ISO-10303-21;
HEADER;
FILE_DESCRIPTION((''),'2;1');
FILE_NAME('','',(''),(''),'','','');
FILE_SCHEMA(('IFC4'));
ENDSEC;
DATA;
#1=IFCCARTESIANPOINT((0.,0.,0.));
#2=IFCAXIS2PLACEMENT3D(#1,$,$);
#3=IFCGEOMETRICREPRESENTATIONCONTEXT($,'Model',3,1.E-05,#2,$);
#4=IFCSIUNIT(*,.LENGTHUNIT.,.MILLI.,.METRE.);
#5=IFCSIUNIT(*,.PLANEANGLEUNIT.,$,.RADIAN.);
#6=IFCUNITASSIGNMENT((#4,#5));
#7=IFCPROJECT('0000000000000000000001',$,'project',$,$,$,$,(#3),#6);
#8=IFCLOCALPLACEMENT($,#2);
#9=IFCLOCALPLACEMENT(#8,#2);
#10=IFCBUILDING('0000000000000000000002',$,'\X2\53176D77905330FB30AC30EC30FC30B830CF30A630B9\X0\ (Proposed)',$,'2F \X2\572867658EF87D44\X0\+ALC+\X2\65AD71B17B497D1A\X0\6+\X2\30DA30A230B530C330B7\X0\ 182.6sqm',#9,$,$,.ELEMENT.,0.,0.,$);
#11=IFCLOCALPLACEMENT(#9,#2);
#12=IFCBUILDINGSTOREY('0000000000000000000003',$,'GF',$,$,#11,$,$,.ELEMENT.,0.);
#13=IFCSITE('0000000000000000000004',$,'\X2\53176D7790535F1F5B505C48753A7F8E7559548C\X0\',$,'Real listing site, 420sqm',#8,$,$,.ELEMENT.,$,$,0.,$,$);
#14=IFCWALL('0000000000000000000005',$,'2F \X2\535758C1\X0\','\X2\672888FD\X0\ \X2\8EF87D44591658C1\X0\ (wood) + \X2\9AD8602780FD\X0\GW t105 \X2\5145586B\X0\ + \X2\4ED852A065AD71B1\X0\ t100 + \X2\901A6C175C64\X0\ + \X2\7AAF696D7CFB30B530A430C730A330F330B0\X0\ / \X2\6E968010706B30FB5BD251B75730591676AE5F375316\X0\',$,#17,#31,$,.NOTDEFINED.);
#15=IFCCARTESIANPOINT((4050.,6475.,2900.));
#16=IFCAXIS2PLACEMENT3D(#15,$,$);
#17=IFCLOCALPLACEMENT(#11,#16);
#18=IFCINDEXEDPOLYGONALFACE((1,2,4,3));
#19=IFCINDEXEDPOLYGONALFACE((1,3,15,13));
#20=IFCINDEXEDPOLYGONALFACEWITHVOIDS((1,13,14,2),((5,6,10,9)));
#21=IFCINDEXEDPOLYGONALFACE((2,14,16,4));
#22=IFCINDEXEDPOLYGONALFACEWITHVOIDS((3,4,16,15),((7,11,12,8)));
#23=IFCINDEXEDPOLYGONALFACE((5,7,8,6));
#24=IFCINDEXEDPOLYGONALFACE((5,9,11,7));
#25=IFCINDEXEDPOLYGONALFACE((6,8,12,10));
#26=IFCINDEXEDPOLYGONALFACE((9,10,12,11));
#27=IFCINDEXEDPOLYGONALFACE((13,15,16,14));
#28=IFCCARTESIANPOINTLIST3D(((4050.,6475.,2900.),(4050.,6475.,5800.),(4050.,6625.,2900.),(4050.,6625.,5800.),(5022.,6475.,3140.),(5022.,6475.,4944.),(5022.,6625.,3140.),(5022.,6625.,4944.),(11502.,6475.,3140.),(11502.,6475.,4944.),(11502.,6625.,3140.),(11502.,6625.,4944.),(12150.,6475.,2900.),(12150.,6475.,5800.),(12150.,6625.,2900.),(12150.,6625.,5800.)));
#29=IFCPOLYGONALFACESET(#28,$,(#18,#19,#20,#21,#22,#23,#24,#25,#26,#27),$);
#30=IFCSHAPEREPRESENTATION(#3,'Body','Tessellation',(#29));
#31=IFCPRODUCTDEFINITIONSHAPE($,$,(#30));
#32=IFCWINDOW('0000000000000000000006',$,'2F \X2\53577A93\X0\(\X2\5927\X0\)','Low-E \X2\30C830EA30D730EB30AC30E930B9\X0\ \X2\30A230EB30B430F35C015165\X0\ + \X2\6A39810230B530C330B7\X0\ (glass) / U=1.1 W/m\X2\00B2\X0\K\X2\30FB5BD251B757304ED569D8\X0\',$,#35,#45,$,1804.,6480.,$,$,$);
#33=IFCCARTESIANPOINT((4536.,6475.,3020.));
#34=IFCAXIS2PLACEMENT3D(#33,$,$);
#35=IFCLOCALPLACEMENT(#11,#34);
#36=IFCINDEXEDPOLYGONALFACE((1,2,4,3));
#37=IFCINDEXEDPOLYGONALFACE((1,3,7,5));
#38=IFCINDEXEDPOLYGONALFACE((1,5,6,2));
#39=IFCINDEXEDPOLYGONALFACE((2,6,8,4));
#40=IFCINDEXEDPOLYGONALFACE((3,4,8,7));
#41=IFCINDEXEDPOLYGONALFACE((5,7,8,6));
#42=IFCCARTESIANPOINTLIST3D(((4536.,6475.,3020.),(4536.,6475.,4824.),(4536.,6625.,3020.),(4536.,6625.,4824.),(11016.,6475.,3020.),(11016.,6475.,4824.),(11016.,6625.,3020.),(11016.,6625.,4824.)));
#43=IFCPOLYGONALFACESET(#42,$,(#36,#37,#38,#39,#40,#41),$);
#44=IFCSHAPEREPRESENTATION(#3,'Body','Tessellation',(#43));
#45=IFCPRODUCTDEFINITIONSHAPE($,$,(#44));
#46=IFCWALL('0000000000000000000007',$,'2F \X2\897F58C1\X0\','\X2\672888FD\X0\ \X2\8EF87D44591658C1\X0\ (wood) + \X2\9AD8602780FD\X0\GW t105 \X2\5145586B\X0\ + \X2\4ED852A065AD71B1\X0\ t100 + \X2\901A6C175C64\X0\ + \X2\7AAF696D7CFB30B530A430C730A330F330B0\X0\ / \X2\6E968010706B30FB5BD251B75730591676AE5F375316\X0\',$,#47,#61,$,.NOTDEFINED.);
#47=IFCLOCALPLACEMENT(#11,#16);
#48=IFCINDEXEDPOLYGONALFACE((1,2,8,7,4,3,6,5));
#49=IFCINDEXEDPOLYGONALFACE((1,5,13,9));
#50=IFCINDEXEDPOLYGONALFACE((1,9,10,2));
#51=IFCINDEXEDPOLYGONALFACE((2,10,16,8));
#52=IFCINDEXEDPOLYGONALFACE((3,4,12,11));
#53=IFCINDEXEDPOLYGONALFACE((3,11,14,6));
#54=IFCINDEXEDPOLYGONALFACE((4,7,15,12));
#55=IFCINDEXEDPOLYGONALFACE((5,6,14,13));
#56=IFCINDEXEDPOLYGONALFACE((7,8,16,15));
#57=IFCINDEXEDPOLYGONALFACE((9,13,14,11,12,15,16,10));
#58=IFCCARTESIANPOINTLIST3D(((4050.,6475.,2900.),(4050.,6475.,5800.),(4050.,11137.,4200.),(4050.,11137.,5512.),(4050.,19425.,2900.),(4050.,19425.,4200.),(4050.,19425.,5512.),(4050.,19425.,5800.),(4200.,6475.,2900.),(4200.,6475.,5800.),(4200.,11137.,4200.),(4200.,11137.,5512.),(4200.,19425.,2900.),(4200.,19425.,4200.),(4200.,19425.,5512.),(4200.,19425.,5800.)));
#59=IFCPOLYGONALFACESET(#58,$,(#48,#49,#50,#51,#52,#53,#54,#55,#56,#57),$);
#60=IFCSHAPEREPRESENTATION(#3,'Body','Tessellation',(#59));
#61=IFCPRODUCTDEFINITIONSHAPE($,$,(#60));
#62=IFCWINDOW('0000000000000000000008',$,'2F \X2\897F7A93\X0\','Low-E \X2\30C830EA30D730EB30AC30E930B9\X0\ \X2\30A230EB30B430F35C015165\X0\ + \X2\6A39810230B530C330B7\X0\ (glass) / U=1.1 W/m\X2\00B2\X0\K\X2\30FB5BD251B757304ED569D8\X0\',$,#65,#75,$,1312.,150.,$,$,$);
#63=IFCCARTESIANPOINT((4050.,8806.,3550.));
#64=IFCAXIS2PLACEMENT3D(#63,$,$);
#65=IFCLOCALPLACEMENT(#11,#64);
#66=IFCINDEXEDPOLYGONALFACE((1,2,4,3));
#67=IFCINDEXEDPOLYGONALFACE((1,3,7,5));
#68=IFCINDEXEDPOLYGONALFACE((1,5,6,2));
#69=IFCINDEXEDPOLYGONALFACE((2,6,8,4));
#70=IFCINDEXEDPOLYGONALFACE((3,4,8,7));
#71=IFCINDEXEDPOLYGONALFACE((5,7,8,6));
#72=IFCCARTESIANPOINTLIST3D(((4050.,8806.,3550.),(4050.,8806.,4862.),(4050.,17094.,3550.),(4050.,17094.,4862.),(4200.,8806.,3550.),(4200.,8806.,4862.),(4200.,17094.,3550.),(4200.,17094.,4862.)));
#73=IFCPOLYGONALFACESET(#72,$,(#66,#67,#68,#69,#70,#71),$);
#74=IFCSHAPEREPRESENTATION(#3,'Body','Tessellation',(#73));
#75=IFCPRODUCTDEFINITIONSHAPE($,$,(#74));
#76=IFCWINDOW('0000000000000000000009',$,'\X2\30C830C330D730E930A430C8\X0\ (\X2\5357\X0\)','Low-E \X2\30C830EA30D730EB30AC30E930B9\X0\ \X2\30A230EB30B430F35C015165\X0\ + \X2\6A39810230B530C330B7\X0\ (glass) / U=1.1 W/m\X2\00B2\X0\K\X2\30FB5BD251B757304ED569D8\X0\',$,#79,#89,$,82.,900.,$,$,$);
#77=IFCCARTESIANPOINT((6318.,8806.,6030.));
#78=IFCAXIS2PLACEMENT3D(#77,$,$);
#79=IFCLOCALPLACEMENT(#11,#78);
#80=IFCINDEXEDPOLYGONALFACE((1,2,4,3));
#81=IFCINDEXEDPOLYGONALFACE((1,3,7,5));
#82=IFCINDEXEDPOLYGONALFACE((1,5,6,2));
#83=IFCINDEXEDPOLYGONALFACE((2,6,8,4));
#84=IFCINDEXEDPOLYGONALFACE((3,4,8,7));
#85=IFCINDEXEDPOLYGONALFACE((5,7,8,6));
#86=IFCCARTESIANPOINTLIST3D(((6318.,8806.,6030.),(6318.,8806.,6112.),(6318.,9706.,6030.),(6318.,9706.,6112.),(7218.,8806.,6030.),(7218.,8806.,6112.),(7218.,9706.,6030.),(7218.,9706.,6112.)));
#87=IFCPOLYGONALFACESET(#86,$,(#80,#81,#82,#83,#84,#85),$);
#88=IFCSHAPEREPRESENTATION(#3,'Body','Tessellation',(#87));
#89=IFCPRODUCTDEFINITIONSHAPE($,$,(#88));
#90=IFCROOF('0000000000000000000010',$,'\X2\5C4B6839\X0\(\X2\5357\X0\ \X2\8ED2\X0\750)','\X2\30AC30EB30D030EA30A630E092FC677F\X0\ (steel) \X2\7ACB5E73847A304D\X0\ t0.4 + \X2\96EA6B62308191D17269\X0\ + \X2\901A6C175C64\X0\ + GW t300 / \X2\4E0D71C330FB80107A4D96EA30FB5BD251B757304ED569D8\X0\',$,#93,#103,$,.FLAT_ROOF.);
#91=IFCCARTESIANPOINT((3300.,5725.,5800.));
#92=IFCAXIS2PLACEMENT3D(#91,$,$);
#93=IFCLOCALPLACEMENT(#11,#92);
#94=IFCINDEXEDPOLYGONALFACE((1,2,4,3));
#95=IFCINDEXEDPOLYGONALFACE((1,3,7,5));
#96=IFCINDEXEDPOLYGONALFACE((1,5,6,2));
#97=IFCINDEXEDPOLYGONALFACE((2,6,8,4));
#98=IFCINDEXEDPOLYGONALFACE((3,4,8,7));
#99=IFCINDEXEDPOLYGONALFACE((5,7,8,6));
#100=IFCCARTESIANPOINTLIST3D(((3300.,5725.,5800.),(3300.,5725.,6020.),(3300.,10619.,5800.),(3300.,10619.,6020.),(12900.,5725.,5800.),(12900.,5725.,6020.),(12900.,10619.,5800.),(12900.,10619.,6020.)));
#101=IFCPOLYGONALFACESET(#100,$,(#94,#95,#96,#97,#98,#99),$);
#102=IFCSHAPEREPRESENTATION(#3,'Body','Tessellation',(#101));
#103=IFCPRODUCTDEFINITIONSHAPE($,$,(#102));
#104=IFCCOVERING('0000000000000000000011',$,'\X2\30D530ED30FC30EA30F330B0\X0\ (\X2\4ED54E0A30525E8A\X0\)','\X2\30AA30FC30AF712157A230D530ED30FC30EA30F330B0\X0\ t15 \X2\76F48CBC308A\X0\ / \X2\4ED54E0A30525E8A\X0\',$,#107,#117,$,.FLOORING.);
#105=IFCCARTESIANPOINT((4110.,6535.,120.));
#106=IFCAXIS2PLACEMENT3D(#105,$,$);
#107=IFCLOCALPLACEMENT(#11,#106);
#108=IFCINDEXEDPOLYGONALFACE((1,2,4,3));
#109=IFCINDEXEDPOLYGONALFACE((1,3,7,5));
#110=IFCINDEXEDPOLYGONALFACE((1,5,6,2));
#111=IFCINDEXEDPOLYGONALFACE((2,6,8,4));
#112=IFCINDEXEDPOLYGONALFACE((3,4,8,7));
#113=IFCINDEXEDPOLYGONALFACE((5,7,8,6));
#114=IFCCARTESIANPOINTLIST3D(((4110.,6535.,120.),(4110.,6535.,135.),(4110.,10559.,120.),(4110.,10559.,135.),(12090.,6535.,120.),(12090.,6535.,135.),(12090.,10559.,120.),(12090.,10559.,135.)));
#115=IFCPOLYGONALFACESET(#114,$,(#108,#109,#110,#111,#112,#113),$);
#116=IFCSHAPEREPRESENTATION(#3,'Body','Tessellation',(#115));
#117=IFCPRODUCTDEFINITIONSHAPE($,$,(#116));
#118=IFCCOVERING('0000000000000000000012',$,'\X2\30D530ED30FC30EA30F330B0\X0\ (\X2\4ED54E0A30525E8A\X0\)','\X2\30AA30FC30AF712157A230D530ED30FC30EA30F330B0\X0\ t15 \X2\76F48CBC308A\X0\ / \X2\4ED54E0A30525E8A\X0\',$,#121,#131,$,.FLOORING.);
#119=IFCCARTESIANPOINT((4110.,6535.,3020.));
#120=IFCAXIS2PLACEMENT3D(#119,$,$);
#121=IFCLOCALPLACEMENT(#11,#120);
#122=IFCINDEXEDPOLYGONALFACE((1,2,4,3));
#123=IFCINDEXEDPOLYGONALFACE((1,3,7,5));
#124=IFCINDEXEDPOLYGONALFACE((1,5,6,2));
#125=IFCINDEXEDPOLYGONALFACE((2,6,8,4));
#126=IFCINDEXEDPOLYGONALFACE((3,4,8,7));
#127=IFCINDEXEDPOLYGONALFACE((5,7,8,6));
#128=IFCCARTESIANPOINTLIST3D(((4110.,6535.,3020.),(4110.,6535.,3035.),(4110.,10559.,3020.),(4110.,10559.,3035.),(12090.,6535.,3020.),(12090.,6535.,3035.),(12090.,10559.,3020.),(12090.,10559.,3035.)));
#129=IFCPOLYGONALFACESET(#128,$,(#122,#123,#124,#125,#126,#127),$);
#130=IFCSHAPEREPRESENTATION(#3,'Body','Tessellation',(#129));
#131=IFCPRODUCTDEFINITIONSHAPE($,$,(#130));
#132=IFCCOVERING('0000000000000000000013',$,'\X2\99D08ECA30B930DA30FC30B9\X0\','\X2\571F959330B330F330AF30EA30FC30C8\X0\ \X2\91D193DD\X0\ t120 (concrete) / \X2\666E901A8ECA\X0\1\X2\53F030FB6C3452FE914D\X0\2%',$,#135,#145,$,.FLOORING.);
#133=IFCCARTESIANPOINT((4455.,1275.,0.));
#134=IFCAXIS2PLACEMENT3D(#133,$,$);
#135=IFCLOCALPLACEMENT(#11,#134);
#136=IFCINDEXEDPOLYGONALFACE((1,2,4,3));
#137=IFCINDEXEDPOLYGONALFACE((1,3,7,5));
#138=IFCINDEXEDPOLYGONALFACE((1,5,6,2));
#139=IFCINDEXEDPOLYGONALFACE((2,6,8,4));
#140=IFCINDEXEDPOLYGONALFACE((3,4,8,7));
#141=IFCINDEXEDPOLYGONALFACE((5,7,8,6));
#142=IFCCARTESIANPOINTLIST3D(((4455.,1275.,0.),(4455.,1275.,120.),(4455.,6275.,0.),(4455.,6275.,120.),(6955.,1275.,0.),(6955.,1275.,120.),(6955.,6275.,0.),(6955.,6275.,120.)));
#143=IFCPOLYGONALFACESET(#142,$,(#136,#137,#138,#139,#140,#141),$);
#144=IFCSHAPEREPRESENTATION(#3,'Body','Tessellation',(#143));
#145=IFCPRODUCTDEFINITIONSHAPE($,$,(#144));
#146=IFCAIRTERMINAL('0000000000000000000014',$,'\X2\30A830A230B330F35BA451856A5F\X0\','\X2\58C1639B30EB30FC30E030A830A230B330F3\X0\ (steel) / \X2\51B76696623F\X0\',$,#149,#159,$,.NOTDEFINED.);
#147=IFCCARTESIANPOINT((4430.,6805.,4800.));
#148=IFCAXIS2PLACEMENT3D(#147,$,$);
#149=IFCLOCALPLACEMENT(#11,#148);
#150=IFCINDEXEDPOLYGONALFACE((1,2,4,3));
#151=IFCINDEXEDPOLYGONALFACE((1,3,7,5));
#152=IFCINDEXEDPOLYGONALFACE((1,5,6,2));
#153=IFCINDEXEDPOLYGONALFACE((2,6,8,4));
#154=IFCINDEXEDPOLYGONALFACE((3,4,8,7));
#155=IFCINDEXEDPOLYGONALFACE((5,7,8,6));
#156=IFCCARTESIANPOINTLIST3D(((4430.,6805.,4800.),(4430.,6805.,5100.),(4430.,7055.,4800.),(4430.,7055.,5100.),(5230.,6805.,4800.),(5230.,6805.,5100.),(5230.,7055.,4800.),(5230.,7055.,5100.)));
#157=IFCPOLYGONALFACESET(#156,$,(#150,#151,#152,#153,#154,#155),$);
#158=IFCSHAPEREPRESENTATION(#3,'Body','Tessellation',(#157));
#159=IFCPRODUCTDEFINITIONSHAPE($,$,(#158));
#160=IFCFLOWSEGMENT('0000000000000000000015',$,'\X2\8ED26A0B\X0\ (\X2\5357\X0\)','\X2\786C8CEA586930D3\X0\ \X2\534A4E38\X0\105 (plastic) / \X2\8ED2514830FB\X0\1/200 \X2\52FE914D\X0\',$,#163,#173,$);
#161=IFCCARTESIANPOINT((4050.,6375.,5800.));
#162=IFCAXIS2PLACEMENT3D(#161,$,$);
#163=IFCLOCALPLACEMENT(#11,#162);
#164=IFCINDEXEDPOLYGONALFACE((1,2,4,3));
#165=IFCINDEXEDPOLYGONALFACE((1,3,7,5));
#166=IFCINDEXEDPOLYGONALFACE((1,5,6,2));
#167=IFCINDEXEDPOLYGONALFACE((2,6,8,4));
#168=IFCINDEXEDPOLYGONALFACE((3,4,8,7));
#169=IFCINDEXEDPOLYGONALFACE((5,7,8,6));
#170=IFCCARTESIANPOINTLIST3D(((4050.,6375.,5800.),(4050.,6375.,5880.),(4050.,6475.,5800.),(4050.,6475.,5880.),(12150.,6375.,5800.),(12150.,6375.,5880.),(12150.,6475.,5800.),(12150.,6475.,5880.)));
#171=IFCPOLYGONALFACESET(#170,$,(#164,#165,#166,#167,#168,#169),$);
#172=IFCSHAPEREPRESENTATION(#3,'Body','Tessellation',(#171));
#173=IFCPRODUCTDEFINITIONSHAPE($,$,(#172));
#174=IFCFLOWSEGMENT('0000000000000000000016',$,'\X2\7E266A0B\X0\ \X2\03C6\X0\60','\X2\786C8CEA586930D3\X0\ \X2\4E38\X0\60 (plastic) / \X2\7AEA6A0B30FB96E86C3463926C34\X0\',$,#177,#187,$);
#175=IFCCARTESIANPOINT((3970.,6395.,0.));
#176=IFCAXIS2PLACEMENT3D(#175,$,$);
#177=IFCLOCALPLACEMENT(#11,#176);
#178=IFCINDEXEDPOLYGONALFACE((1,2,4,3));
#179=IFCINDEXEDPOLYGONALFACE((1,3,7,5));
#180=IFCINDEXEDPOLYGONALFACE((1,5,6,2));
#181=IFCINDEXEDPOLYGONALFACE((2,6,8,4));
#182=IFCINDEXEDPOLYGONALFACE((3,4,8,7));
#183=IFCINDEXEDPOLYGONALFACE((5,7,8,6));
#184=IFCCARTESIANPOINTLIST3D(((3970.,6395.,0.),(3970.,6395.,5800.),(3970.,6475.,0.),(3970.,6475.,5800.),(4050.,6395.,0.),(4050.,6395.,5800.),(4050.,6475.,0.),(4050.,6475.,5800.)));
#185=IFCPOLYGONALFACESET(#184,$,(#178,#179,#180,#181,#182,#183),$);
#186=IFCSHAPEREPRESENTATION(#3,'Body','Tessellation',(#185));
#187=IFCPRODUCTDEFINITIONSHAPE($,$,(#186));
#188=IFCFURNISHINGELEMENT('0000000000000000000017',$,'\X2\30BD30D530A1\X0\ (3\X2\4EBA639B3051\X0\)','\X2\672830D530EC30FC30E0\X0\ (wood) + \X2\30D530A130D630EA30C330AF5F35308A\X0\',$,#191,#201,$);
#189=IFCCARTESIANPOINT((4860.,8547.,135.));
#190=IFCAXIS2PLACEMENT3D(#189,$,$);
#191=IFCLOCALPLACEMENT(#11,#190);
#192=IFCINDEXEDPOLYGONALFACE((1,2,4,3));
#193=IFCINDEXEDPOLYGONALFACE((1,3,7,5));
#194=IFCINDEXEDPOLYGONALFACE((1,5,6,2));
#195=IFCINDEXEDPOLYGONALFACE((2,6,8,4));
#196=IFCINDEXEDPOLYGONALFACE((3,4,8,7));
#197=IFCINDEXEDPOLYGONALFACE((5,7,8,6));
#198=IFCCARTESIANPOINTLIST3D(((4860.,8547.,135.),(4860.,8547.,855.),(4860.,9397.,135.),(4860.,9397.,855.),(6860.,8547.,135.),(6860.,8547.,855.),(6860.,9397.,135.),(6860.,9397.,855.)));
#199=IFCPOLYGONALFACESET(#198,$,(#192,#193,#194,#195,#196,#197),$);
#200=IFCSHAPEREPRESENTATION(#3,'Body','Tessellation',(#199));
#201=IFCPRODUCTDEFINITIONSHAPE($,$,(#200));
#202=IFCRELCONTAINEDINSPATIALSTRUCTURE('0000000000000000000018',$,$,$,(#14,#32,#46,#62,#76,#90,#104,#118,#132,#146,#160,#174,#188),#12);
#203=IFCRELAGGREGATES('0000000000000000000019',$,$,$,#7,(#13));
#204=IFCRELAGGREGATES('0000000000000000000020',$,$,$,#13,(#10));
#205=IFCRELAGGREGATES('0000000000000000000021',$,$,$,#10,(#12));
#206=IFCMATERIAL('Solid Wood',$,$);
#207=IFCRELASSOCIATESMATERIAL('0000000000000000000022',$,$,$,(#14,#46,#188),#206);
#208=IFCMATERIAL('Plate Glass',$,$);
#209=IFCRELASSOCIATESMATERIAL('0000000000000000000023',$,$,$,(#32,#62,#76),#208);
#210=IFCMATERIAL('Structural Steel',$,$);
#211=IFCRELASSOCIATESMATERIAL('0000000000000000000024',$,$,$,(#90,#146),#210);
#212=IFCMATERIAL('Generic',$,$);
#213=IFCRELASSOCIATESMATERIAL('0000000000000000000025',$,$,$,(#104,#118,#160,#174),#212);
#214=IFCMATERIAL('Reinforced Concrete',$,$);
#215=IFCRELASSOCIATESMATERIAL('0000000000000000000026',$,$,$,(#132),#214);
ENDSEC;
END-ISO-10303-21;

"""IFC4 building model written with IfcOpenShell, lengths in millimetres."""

from ifc_helpers import new_model, si_unit, frame, frame_2d, origin, place, context, project, spatial, rectangle, extrude, material, element, fill, save


model = new_model("IFC4")

# Units and contexts
model_context = context("Model", 3, precision=1e-05, world=origin())
ifc_project = project(units=[si_unit("LENGTHUNIT", "METRE", prefix="MILLI"), si_unit("PLANEANGLEUNIT", "RADIAN")], contexts=[model_context])

# Site, building, storey
site_placement = place(None, origin())
site = spatial("IfcSite", under=ifc_project, at=site_placement, Name="北海道弟子屈町美留和", ObjectType="Real listing site, 420sqm", CompositionType="ELEMENT", RefElevation=0.0)
building_placement = place(site_placement, origin())
building = spatial("IfcBuilding", under=site, at=building_placement, Name="北海道・ガレージハウス (Proposed)", ObjectType="2F 在来軸組+ALC+断熱等級6+ペアサッシ 182.6sqm", CompositionType="ELEMENT", ElevationOfRefHeight=0.0, ElevationOfTerrain=0.0)
storey_placement = place(building_placement, origin())
storey = spatial("IfcBuildingStorey", under=building, at=storey_placement, Name="GF", CompositionType="ELEMENT", Elevation=0.0)

# Shared definitions
ifc_material_1 = material(Name="Solid Wood")

# Shared definitions
ifc_material_2 = material(Name="Reinforced Concrete")

# Shared definitions
ifc_material_3 = material(Name="Plate Glass")

# Walls, openings, windows
wall_1_placement = place(storey_placement, frame((4050.0, 6475.0, 2900.0)))
wall_1 = element("IfcWall", 1, at=wall_1_placement, inside=storey, material=ifc_material_1, Name="2F 南壁", Description="木製 軸組外壁 (wood) + 高性能GW t105 充填 + 付加断熱 t100 + 通気層 + 窯業系サイディング / 準耐火・寒冷地外皮強化", PredefinedType="NOTDEFINED", context=model_context, shape_type="SweptSolid", body=[
    extrude(rectangle(XDim=8100.0, YDim=150.0, at=frame_2d((4050.0, 75.0))), frame((4050.0, 6475.0, 2900.0)), (0.0, 0.0, 1.0), 2900.0),
])
opening_1_placement = place(storey_placement, frame((4536.0, 6475.0, 3020.0)))
opening_1 = element("IfcOpeningElement", 2, at=opening_1_placement, cuts=wall_1, PredefinedType="NOTDEFINED", context=model_context, shape_type="SweptSolid", body=[
    extrude(rectangle(XDim=6480.0, YDim=150.0, at=frame_2d((3240.0, 75.0))), frame((4536.0, 6475.0, 3020.0)), (0.0, 0.0, 1.0), 1804.0),
])
window_1_placement = place(storey_placement, frame((4536.0, 6475.0, 3020.0)))
window_1 = element("IfcWindow", 3, at=window_1_placement, inside=storey, material=ifc_material_3, Name="2F 南窓(大)", Description="Low-E トリプルガラス アルゴン封入 + 樹脂サッシ (glass) / U=1.1 W/m²K・寒冷地仕様", OverallHeight=1804.0, OverallWidth=6480.0, context=model_context, shape_type="SweptSolid", body=[
    extrude(rectangle(XDim=6480.0, YDim=150.0, at=frame_2d((3240.0, 75.0))), frame((4536.0, 6475.0, 3020.0)), (0.0, 0.0, 1.0), 1804.0),
])
fill(opening_1, window_1)
wall_2_placement = place(storey_placement, frame((4050.0, 6475.0, 2900.0)))
wall_2 = element("IfcWall", 4, at=wall_2_placement, inside=storey, material=ifc_material_1, Name="2F 西壁", Description="木製 軸組外壁 (wood) + 高性能GW t105 充填 + 付加断熱 t100 + 通気層 + 窯業系サイディング / 準耐火・寒冷地外皮強化", PredefinedType="NOTDEFINED", context=model_context, shape_type="SweptSolid", body=[
    extrude(rectangle(XDim=150.0, YDim=12950.0, at=frame_2d((75.0, 6475.0))), frame((4050.0, 6475.0, 2900.0)), (0.0, 0.0, 1.0), 2900.0),
])
opening_2_placement = place(storey_placement, frame((4050.0, 8806.0, 3550.0)))
opening_2 = element("IfcOpeningElement", 5, at=opening_2_placement, cuts=wall_2, PredefinedType="NOTDEFINED", context=model_context, shape_type="SweptSolid", body=[
    extrude(rectangle(XDim=150.0, YDim=8288.0, at=frame_2d((75.0, 4144.0))), frame((4050.0, 8806.0, 3550.0)), (0.0, 0.0, 1.0), 1312.0),
])
window_2_placement = place(storey_placement, frame((4050.0, 8806.0, 3550.0)))
window_2 = element("IfcWindow", 6, at=window_2_placement, inside=storey, material=ifc_material_3, Name="2F 西窓", Description="Low-E トリプルガラス アルゴン封入 + 樹脂サッシ (glass) / U=1.1 W/m²K・寒冷地仕様", OverallHeight=1312.0, OverallWidth=150.0, context=model_context, shape_type="SweptSolid", body=[
    extrude(rectangle(XDim=150.0, YDim=8288.0, at=frame_2d((75.0, 4144.0))), frame((4050.0, 8806.0, 3550.0)), (0.0, 0.0, 1.0), 1312.0),
])
fill(opening_2, window_2)

# Window
window_3_placement = place(storey_placement, frame((6318.0, 8806.0, 6030.0)))
element("IfcWindow", 7, at=window_3_placement, inside=storey, material=ifc_material_3, Name="トップライト (南)", Description="Low-E トリプルガラス アルゴン封入 + 樹脂サッシ (glass) / U=1.1 W/m²K・寒冷地仕様", OverallHeight=82.0, OverallWidth=900.0, context=model_context, shape_type="SweptSolid", body=[
    extrude(rectangle(XDim=900.0, YDim=900.0, at=frame_2d((450.0, 450.0))), frame((6318.0, 8806.0, 6030.0)), (0.0, 0.0, 1.0), 82.0),
])

# Roof
ifc_material_4 = material(Name="Structural Steel")
for number, where, name in (
    (8, (3300.0, 5725.0, 5800.0), "屋根(南 軒750)"),
):
    element("IfcRoof", number, at=place(storey_placement, frame(where)), inside=storey, material=ifc_material_4, Name=name, Description="ガルバリウム鋼板 (steel) 立平葺き t0.4 + 雪止め金物 + 通気層 + GW t300 / 不燃・耐積雪・寒冷地仕様", PredefinedType="FLAT_ROOF", context=model_context, shape_type="SweptSolid", body=[
        extrude(rectangle(XDim=9600.0, YDim=4894.0, at=frame_2d((4800.0, 2447.0))), frame((3300.0, 5725.0, 5800.0)), (0.0, 0.0, 1.0), 220.0),
    ])

# Coverings
ifc_material_5 = material(Name="Generic")
covering_1_placement = place(storey_placement, frame((4110.0, 6535.0, 120.0)))
element("IfcCovering", 9, at=covering_1_placement, inside=storey, material=ifc_material_5, Name="フローリング (仕上げ床)", Description="オーク無垢フローリング t15 直貼り / 仕上げ床", PredefinedType="FLOORING", context=model_context, shape_type="SweptSolid", body=[
    extrude(rectangle(XDim=7980.0, YDim=4024.0, at=frame_2d((3990.0, 2012.0))), frame((4110.0, 6535.0, 120.0)), (0.0, 0.0, 1.0), 15.0),
])
covering_2_placement = place(storey_placement, frame((4110.0, 6535.0, 3020.0)))
element("IfcCovering", 10, at=covering_2_placement, inside=storey, material=ifc_material_5, Name="フローリング (仕上げ床)", Description="オーク無垢フローリング t15 直貼り / 仕上げ床", PredefinedType="FLOORING", context=model_context, shape_type="SweptSolid", body=[
    extrude(rectangle(XDim=7980.0, YDim=4024.0, at=frame_2d((3990.0, 2012.0))), frame((4110.0, 6535.0, 3020.0)), (0.0, 0.0, 1.0), 15.0),
])
covering_3_placement = place(storey_placement, frame((4455.0, 1275.0, 0.0)))
element("IfcCovering", 11, at=covering_3_placement, inside=storey, material=ifc_material_2, Name="駐車スペース", Description="土間コンクリート 金鏝 t120 (concrete) / 普通車1台・水勾配2%", PredefinedType="FLOORING", context=model_context, shape_type="SweptSolid", body=[
    extrude(rectangle(XDim=2500.0, YDim=5000.0, at=frame_2d((1250.0, 2500.0))), frame((4455.0, 1275.0, 0.0)), (0.0, 0.0, 1.0), 120.0),
])

# Air terminal
air_terminal_placement = place(storey_placement, frame((4430.0, 6805.0, 4800.0)))
element("IfcAirTerminal", 12, at=air_terminal_placement, inside=storey, material=ifc_material_4, Name="エアコン室内機", Description="壁掛ルームエアコン (steel) / 冷暖房", PredefinedType="NOTDEFINED", context=model_context, shape_type="SweptSolid", body=[
    extrude(rectangle(XDim=800.0, YDim=250.0, at=frame_2d((400.0, 125.0))), frame((4430.0, 6805.0, 4800.0)), (0.0, 0.0, 1.0), 300.0),
])

# Flow segments
flow_segment_1_placement = place(storey_placement, frame((4050.0, 6375.0, 5800.0)))
element("IfcFlowSegment", 13, at=flow_segment_1_placement, inside=storey, material=ifc_material_5, Name="軒樋 (南)", Description="硬質塩ビ 半丸105 (plastic) / 軒先・1/200 勾配", context=model_context, shape_type="SweptSolid", body=[
    extrude(rectangle(XDim=8100.0, YDim=100.0, at=frame_2d((4050.0, 50.0))), frame((4050.0, 6375.0, 5800.0)), (0.0, 0.0, 1.0), 80.0),
])
flow_segment_2_placement = place(storey_placement, frame((3970.0, 6395.0, 0.0)))
element("IfcFlowSegment", 14, at=flow_segment_2_placement, inside=storey, material=ifc_material_5, Name="縦樋 φ60", Description="硬質塩ビ 丸60 (plastic) / 竪樋・雨水排水", context=model_context, shape_type="SweptSolid", body=[
    extrude(rectangle(XDim=80.0, YDim=80.0, at=frame_2d((40.0, 40.0))), frame((3970.0, 6395.0, 0.0)), (0.0, 0.0, 1.0), 5800.0),
])

# Furnishing element
furnishing_1_placement = place(storey_placement, frame((4860.0, 8547.0, 135.0)))
element("IfcFurnishingElement", 15, at=furnishing_1_placement, inside=storey, material=ifc_material_1, Name="ソファ (3人掛け)", Description="木フレーム (wood) + ファブリック張り", context=model_context, shape_type="SweptSolid", body=[
    extrude(rectangle(XDim=2000.0, YDim=850.0, at=frame_2d((1000.0, 425.0))), frame((4860.0, 8547.0, 135.0)), (0.0, 0.0, 1.0), 720.0),
])

save(model, "model.ifc")
